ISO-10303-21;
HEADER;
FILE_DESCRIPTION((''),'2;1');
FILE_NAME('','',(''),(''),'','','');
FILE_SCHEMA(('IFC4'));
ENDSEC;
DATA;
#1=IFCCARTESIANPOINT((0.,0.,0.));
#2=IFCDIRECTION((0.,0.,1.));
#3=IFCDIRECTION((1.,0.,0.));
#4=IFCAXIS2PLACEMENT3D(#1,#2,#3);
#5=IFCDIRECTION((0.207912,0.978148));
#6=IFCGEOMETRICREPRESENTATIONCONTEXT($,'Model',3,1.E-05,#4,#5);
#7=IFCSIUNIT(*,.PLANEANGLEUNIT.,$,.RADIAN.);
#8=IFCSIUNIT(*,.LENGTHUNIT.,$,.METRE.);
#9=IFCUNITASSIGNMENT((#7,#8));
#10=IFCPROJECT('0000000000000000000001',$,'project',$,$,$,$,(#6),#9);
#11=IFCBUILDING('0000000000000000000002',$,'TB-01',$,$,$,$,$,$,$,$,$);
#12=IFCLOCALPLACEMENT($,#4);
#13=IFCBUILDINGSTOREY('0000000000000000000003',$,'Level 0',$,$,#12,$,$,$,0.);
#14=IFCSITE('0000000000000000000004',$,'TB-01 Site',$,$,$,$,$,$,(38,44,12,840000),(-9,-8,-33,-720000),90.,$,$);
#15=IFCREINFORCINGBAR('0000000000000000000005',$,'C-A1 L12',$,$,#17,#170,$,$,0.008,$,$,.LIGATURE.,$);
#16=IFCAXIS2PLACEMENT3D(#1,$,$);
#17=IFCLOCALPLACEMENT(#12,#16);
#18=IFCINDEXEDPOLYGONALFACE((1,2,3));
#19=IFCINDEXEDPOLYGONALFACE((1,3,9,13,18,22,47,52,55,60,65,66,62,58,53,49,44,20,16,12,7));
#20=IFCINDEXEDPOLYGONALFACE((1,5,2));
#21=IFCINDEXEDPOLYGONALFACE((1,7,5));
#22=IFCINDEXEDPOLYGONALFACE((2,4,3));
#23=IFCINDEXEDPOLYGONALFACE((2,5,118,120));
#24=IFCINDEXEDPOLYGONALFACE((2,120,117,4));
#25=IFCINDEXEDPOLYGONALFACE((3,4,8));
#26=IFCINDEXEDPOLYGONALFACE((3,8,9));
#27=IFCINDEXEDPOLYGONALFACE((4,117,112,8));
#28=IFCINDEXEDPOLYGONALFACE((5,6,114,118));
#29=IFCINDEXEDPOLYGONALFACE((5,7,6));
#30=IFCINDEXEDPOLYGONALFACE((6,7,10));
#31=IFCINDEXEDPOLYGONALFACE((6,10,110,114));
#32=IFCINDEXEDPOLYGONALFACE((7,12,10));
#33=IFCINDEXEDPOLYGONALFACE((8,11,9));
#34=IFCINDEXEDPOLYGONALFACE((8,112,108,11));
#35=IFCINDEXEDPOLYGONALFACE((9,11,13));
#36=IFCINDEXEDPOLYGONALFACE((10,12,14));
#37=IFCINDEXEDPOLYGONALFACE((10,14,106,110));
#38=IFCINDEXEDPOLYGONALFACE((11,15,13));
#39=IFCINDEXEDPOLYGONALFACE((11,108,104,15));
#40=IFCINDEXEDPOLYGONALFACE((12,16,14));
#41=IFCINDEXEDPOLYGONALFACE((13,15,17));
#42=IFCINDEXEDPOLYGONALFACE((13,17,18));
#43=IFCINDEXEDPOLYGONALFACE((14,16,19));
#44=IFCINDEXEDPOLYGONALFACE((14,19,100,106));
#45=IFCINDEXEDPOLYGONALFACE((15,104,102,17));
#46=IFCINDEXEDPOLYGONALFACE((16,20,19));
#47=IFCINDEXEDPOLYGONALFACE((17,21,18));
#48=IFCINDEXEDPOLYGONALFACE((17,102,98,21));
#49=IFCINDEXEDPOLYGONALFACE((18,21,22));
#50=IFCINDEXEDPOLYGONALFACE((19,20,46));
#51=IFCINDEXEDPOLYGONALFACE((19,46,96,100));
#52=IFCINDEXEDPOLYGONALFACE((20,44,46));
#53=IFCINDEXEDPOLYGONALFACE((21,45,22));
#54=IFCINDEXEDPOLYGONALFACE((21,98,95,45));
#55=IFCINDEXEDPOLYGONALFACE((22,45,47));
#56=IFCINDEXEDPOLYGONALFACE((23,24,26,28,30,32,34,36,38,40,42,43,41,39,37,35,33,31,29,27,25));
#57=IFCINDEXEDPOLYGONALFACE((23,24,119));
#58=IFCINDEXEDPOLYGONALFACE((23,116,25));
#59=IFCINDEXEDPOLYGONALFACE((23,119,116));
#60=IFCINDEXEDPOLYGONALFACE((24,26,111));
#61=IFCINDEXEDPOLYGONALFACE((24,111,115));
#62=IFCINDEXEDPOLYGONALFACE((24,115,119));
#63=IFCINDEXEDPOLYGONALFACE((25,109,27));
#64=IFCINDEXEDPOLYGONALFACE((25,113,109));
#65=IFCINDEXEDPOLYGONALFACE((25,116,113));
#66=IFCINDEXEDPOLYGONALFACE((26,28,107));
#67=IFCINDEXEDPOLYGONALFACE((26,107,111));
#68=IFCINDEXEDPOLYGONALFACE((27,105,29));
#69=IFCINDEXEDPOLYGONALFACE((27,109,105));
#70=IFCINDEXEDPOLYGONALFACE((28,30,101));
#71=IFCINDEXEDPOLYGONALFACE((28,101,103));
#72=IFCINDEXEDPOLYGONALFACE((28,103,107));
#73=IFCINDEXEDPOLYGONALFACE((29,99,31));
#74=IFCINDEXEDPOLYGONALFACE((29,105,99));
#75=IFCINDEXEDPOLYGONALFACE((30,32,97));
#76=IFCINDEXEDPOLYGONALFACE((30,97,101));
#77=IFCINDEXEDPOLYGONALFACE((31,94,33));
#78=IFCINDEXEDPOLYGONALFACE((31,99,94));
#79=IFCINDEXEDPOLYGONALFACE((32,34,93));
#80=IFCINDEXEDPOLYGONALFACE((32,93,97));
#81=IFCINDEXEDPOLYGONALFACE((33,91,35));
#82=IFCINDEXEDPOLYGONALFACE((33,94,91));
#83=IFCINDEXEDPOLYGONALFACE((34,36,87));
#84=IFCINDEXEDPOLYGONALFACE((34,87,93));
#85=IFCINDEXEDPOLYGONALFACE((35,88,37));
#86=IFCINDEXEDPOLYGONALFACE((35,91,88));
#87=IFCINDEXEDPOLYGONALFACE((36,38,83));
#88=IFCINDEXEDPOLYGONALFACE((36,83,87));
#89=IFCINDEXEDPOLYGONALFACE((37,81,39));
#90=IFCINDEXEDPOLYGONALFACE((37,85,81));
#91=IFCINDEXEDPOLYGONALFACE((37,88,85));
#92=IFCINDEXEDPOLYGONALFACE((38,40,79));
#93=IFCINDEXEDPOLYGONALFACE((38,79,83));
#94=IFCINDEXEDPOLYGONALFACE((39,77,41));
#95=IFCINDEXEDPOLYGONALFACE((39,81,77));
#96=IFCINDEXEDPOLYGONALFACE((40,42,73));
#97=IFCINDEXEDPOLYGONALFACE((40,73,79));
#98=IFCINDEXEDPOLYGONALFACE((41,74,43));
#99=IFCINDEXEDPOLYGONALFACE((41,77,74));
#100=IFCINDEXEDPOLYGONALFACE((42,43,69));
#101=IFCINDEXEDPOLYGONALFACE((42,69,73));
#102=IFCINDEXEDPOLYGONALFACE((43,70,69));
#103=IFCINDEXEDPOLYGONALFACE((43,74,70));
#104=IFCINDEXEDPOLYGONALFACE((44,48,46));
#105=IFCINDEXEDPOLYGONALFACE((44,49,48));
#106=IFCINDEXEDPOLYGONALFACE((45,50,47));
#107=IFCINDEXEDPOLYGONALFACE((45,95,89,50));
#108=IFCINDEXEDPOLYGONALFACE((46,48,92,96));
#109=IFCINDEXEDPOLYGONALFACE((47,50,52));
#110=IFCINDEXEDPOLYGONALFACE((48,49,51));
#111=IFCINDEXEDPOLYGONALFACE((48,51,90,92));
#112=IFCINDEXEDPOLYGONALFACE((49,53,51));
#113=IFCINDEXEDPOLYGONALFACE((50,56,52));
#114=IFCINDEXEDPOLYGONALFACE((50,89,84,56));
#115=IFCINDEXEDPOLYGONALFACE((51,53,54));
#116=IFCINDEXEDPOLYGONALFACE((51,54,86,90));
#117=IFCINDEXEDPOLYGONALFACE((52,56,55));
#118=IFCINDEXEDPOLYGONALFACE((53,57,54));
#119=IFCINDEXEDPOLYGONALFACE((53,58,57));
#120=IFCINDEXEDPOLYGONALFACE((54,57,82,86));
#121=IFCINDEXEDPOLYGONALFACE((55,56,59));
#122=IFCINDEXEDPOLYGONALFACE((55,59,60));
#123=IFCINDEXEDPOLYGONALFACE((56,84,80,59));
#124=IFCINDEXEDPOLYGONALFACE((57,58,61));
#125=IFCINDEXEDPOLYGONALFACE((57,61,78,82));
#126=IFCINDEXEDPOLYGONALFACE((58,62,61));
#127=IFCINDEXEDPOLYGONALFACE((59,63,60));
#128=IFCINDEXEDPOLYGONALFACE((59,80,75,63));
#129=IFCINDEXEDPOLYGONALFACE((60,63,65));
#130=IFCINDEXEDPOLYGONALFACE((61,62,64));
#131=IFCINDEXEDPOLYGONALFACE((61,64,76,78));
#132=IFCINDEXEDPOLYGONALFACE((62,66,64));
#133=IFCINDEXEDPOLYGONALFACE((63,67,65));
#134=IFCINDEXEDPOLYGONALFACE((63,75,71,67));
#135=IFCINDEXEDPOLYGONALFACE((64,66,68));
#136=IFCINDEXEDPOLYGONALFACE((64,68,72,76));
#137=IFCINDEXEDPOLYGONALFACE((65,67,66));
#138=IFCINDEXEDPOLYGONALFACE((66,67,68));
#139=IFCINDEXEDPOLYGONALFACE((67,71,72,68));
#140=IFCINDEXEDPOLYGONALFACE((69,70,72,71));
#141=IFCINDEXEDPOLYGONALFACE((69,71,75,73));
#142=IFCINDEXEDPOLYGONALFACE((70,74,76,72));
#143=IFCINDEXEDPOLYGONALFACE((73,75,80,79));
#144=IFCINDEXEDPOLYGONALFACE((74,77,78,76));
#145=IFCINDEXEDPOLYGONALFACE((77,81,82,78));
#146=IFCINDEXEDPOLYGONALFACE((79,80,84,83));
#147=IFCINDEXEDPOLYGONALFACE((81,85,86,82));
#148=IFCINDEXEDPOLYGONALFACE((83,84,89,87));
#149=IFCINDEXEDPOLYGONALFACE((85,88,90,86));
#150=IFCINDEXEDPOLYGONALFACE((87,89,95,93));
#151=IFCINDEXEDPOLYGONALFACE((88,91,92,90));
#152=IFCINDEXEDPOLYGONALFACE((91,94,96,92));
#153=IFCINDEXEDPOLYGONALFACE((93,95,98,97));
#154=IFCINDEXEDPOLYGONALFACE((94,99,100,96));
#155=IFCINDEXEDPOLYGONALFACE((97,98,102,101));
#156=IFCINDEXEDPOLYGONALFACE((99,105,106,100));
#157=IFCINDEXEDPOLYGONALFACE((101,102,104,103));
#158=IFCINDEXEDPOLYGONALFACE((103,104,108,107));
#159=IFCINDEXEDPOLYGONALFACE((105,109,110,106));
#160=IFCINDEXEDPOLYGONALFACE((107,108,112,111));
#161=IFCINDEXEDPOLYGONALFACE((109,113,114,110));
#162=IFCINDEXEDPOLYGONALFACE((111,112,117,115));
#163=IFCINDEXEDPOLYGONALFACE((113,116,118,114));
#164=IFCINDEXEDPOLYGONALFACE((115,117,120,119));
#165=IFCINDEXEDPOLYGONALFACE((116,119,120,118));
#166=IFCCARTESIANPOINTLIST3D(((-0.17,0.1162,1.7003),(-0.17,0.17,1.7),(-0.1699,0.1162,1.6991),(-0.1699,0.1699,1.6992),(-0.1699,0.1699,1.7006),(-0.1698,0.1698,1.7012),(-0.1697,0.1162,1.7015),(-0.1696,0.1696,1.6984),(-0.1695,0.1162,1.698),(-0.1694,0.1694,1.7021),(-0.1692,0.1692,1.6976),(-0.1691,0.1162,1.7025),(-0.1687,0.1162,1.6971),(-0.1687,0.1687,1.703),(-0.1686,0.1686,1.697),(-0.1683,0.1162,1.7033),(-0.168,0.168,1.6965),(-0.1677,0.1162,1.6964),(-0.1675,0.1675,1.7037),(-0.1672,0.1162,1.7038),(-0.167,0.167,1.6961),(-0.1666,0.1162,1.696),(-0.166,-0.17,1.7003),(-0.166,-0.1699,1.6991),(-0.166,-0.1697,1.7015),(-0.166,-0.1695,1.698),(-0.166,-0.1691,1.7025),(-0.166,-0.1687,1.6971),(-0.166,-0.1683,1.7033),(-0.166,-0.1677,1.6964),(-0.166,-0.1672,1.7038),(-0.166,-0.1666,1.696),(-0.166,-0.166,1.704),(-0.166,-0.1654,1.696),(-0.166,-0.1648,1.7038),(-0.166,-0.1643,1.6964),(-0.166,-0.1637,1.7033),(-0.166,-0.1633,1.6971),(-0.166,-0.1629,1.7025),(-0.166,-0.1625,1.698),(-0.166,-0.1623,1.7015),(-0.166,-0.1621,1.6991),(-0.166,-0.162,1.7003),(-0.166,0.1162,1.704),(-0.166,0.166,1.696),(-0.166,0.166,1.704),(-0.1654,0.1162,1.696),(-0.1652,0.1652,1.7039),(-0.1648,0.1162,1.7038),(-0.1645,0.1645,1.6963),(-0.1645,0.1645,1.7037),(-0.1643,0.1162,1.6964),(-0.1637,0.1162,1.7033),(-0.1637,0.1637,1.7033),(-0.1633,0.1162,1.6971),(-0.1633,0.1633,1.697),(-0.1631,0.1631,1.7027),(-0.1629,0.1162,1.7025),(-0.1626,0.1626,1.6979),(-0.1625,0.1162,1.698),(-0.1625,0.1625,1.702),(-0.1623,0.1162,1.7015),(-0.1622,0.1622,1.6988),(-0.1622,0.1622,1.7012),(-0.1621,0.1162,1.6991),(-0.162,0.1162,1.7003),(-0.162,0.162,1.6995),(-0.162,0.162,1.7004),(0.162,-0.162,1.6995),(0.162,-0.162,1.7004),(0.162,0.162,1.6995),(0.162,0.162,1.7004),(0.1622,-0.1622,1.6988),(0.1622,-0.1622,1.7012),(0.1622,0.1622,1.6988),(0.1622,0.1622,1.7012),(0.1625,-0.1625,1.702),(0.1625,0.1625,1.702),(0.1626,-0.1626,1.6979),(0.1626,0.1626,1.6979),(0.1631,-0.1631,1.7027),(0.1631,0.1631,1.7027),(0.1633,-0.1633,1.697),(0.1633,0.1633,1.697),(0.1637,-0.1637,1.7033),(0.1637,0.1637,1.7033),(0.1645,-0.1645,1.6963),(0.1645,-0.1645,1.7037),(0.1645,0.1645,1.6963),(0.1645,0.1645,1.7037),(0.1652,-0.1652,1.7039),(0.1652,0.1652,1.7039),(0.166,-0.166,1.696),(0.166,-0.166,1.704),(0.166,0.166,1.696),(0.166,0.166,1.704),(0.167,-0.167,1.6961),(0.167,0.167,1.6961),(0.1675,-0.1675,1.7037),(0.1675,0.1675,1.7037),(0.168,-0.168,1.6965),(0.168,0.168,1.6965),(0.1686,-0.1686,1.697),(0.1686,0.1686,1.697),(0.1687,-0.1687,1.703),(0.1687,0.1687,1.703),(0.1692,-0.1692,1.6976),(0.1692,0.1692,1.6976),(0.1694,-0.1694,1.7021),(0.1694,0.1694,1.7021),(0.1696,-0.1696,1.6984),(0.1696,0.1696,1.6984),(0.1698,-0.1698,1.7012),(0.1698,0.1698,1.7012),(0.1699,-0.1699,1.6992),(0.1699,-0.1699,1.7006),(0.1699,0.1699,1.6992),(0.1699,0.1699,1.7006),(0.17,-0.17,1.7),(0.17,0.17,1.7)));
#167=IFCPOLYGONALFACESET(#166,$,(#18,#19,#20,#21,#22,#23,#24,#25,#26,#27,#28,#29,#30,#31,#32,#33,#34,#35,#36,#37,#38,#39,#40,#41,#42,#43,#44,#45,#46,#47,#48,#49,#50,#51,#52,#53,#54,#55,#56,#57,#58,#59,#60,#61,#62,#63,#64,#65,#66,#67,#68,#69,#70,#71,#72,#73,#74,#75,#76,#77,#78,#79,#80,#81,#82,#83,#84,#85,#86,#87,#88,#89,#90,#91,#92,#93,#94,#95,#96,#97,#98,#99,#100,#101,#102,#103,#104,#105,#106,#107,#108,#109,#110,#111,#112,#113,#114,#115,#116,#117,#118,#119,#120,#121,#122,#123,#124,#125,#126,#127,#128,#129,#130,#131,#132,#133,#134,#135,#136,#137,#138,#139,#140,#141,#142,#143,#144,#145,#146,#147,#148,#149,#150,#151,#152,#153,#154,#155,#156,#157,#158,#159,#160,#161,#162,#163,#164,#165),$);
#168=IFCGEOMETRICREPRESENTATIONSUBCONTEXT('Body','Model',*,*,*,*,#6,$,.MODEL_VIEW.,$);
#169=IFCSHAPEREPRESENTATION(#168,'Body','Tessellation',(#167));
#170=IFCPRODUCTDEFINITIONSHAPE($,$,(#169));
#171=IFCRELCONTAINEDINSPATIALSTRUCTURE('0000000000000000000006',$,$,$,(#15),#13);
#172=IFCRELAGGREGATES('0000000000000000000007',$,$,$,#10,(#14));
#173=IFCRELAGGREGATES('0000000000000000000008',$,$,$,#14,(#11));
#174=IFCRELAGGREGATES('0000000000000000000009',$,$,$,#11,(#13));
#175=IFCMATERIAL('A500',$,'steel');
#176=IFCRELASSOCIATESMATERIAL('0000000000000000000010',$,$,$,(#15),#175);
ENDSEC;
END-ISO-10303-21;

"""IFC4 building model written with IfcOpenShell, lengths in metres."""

from ifc_helpers import new_model, entity, si_unit, direction, origin_with_axes, place, context, subcontext, project, spatial, material, element, save


model = new_model("IFC4")

# Units and contexts
model_context = context("Model", 3, precision=1e-05, world=origin_with_axes(), true_north=direction((0.207912, 0.978148)))
body_context = subcontext(model_context, "Body", "Model", "MODEL_VIEW")
ifc_project = project(units=[si_unit("PLANEANGLEUNIT", "RADIAN"), si_unit("LENGTHUNIT", "METRE")], contexts=[model_context])

# Site, building, storey
site = spatial("IfcSite", under=ifc_project, Name="TB-01 Site", RefLatitude=(38, 44, 12, 840000), RefLongitude=(-9, -8, -33, -720000), RefElevation=90.0)
building = spatial("IfcBuilding", under=site, Name="TB-01")
storey_placement = place(None, origin_with_axes())
storey = spatial("IfcBuildingStorey", under=building, at=storey_placement, Name="Level 0", Elevation=0.0)

# Reinforcing bar
ifc_material_1 = material(Name="A500", Category="steel")
reinforcing_bar_1_placement = place(storey_placement, origin_with_axes())
element("IfcReinforcingBar", 1, at=reinforcing_bar_1_placement, inside=storey, material=ifc_material_1, Name="C-A1 L12", NominalDiameter=0.008, PredefinedType="LIGATURE", context=body_context, shape_type="AdvancedSweptSolid", body=[
    entity("IfcSweptDiskSolid", entity("IfcPolyline", [entity("IfcCartesianPoint", [-0.166, -0.166, 1.7]), entity("IfcCartesianPoint", [0.166, -0.166, 1.7]), entity("IfcCartesianPoint", [0.166, 0.166, 1.7]), entity("IfcCartesianPoint", [-0.166, 0.166, 1.7]), entity("IfcCartesianPoint", [-0.166, 0.1162, 1.7])]), 0.004),
])

save(model, "model.ifc")
